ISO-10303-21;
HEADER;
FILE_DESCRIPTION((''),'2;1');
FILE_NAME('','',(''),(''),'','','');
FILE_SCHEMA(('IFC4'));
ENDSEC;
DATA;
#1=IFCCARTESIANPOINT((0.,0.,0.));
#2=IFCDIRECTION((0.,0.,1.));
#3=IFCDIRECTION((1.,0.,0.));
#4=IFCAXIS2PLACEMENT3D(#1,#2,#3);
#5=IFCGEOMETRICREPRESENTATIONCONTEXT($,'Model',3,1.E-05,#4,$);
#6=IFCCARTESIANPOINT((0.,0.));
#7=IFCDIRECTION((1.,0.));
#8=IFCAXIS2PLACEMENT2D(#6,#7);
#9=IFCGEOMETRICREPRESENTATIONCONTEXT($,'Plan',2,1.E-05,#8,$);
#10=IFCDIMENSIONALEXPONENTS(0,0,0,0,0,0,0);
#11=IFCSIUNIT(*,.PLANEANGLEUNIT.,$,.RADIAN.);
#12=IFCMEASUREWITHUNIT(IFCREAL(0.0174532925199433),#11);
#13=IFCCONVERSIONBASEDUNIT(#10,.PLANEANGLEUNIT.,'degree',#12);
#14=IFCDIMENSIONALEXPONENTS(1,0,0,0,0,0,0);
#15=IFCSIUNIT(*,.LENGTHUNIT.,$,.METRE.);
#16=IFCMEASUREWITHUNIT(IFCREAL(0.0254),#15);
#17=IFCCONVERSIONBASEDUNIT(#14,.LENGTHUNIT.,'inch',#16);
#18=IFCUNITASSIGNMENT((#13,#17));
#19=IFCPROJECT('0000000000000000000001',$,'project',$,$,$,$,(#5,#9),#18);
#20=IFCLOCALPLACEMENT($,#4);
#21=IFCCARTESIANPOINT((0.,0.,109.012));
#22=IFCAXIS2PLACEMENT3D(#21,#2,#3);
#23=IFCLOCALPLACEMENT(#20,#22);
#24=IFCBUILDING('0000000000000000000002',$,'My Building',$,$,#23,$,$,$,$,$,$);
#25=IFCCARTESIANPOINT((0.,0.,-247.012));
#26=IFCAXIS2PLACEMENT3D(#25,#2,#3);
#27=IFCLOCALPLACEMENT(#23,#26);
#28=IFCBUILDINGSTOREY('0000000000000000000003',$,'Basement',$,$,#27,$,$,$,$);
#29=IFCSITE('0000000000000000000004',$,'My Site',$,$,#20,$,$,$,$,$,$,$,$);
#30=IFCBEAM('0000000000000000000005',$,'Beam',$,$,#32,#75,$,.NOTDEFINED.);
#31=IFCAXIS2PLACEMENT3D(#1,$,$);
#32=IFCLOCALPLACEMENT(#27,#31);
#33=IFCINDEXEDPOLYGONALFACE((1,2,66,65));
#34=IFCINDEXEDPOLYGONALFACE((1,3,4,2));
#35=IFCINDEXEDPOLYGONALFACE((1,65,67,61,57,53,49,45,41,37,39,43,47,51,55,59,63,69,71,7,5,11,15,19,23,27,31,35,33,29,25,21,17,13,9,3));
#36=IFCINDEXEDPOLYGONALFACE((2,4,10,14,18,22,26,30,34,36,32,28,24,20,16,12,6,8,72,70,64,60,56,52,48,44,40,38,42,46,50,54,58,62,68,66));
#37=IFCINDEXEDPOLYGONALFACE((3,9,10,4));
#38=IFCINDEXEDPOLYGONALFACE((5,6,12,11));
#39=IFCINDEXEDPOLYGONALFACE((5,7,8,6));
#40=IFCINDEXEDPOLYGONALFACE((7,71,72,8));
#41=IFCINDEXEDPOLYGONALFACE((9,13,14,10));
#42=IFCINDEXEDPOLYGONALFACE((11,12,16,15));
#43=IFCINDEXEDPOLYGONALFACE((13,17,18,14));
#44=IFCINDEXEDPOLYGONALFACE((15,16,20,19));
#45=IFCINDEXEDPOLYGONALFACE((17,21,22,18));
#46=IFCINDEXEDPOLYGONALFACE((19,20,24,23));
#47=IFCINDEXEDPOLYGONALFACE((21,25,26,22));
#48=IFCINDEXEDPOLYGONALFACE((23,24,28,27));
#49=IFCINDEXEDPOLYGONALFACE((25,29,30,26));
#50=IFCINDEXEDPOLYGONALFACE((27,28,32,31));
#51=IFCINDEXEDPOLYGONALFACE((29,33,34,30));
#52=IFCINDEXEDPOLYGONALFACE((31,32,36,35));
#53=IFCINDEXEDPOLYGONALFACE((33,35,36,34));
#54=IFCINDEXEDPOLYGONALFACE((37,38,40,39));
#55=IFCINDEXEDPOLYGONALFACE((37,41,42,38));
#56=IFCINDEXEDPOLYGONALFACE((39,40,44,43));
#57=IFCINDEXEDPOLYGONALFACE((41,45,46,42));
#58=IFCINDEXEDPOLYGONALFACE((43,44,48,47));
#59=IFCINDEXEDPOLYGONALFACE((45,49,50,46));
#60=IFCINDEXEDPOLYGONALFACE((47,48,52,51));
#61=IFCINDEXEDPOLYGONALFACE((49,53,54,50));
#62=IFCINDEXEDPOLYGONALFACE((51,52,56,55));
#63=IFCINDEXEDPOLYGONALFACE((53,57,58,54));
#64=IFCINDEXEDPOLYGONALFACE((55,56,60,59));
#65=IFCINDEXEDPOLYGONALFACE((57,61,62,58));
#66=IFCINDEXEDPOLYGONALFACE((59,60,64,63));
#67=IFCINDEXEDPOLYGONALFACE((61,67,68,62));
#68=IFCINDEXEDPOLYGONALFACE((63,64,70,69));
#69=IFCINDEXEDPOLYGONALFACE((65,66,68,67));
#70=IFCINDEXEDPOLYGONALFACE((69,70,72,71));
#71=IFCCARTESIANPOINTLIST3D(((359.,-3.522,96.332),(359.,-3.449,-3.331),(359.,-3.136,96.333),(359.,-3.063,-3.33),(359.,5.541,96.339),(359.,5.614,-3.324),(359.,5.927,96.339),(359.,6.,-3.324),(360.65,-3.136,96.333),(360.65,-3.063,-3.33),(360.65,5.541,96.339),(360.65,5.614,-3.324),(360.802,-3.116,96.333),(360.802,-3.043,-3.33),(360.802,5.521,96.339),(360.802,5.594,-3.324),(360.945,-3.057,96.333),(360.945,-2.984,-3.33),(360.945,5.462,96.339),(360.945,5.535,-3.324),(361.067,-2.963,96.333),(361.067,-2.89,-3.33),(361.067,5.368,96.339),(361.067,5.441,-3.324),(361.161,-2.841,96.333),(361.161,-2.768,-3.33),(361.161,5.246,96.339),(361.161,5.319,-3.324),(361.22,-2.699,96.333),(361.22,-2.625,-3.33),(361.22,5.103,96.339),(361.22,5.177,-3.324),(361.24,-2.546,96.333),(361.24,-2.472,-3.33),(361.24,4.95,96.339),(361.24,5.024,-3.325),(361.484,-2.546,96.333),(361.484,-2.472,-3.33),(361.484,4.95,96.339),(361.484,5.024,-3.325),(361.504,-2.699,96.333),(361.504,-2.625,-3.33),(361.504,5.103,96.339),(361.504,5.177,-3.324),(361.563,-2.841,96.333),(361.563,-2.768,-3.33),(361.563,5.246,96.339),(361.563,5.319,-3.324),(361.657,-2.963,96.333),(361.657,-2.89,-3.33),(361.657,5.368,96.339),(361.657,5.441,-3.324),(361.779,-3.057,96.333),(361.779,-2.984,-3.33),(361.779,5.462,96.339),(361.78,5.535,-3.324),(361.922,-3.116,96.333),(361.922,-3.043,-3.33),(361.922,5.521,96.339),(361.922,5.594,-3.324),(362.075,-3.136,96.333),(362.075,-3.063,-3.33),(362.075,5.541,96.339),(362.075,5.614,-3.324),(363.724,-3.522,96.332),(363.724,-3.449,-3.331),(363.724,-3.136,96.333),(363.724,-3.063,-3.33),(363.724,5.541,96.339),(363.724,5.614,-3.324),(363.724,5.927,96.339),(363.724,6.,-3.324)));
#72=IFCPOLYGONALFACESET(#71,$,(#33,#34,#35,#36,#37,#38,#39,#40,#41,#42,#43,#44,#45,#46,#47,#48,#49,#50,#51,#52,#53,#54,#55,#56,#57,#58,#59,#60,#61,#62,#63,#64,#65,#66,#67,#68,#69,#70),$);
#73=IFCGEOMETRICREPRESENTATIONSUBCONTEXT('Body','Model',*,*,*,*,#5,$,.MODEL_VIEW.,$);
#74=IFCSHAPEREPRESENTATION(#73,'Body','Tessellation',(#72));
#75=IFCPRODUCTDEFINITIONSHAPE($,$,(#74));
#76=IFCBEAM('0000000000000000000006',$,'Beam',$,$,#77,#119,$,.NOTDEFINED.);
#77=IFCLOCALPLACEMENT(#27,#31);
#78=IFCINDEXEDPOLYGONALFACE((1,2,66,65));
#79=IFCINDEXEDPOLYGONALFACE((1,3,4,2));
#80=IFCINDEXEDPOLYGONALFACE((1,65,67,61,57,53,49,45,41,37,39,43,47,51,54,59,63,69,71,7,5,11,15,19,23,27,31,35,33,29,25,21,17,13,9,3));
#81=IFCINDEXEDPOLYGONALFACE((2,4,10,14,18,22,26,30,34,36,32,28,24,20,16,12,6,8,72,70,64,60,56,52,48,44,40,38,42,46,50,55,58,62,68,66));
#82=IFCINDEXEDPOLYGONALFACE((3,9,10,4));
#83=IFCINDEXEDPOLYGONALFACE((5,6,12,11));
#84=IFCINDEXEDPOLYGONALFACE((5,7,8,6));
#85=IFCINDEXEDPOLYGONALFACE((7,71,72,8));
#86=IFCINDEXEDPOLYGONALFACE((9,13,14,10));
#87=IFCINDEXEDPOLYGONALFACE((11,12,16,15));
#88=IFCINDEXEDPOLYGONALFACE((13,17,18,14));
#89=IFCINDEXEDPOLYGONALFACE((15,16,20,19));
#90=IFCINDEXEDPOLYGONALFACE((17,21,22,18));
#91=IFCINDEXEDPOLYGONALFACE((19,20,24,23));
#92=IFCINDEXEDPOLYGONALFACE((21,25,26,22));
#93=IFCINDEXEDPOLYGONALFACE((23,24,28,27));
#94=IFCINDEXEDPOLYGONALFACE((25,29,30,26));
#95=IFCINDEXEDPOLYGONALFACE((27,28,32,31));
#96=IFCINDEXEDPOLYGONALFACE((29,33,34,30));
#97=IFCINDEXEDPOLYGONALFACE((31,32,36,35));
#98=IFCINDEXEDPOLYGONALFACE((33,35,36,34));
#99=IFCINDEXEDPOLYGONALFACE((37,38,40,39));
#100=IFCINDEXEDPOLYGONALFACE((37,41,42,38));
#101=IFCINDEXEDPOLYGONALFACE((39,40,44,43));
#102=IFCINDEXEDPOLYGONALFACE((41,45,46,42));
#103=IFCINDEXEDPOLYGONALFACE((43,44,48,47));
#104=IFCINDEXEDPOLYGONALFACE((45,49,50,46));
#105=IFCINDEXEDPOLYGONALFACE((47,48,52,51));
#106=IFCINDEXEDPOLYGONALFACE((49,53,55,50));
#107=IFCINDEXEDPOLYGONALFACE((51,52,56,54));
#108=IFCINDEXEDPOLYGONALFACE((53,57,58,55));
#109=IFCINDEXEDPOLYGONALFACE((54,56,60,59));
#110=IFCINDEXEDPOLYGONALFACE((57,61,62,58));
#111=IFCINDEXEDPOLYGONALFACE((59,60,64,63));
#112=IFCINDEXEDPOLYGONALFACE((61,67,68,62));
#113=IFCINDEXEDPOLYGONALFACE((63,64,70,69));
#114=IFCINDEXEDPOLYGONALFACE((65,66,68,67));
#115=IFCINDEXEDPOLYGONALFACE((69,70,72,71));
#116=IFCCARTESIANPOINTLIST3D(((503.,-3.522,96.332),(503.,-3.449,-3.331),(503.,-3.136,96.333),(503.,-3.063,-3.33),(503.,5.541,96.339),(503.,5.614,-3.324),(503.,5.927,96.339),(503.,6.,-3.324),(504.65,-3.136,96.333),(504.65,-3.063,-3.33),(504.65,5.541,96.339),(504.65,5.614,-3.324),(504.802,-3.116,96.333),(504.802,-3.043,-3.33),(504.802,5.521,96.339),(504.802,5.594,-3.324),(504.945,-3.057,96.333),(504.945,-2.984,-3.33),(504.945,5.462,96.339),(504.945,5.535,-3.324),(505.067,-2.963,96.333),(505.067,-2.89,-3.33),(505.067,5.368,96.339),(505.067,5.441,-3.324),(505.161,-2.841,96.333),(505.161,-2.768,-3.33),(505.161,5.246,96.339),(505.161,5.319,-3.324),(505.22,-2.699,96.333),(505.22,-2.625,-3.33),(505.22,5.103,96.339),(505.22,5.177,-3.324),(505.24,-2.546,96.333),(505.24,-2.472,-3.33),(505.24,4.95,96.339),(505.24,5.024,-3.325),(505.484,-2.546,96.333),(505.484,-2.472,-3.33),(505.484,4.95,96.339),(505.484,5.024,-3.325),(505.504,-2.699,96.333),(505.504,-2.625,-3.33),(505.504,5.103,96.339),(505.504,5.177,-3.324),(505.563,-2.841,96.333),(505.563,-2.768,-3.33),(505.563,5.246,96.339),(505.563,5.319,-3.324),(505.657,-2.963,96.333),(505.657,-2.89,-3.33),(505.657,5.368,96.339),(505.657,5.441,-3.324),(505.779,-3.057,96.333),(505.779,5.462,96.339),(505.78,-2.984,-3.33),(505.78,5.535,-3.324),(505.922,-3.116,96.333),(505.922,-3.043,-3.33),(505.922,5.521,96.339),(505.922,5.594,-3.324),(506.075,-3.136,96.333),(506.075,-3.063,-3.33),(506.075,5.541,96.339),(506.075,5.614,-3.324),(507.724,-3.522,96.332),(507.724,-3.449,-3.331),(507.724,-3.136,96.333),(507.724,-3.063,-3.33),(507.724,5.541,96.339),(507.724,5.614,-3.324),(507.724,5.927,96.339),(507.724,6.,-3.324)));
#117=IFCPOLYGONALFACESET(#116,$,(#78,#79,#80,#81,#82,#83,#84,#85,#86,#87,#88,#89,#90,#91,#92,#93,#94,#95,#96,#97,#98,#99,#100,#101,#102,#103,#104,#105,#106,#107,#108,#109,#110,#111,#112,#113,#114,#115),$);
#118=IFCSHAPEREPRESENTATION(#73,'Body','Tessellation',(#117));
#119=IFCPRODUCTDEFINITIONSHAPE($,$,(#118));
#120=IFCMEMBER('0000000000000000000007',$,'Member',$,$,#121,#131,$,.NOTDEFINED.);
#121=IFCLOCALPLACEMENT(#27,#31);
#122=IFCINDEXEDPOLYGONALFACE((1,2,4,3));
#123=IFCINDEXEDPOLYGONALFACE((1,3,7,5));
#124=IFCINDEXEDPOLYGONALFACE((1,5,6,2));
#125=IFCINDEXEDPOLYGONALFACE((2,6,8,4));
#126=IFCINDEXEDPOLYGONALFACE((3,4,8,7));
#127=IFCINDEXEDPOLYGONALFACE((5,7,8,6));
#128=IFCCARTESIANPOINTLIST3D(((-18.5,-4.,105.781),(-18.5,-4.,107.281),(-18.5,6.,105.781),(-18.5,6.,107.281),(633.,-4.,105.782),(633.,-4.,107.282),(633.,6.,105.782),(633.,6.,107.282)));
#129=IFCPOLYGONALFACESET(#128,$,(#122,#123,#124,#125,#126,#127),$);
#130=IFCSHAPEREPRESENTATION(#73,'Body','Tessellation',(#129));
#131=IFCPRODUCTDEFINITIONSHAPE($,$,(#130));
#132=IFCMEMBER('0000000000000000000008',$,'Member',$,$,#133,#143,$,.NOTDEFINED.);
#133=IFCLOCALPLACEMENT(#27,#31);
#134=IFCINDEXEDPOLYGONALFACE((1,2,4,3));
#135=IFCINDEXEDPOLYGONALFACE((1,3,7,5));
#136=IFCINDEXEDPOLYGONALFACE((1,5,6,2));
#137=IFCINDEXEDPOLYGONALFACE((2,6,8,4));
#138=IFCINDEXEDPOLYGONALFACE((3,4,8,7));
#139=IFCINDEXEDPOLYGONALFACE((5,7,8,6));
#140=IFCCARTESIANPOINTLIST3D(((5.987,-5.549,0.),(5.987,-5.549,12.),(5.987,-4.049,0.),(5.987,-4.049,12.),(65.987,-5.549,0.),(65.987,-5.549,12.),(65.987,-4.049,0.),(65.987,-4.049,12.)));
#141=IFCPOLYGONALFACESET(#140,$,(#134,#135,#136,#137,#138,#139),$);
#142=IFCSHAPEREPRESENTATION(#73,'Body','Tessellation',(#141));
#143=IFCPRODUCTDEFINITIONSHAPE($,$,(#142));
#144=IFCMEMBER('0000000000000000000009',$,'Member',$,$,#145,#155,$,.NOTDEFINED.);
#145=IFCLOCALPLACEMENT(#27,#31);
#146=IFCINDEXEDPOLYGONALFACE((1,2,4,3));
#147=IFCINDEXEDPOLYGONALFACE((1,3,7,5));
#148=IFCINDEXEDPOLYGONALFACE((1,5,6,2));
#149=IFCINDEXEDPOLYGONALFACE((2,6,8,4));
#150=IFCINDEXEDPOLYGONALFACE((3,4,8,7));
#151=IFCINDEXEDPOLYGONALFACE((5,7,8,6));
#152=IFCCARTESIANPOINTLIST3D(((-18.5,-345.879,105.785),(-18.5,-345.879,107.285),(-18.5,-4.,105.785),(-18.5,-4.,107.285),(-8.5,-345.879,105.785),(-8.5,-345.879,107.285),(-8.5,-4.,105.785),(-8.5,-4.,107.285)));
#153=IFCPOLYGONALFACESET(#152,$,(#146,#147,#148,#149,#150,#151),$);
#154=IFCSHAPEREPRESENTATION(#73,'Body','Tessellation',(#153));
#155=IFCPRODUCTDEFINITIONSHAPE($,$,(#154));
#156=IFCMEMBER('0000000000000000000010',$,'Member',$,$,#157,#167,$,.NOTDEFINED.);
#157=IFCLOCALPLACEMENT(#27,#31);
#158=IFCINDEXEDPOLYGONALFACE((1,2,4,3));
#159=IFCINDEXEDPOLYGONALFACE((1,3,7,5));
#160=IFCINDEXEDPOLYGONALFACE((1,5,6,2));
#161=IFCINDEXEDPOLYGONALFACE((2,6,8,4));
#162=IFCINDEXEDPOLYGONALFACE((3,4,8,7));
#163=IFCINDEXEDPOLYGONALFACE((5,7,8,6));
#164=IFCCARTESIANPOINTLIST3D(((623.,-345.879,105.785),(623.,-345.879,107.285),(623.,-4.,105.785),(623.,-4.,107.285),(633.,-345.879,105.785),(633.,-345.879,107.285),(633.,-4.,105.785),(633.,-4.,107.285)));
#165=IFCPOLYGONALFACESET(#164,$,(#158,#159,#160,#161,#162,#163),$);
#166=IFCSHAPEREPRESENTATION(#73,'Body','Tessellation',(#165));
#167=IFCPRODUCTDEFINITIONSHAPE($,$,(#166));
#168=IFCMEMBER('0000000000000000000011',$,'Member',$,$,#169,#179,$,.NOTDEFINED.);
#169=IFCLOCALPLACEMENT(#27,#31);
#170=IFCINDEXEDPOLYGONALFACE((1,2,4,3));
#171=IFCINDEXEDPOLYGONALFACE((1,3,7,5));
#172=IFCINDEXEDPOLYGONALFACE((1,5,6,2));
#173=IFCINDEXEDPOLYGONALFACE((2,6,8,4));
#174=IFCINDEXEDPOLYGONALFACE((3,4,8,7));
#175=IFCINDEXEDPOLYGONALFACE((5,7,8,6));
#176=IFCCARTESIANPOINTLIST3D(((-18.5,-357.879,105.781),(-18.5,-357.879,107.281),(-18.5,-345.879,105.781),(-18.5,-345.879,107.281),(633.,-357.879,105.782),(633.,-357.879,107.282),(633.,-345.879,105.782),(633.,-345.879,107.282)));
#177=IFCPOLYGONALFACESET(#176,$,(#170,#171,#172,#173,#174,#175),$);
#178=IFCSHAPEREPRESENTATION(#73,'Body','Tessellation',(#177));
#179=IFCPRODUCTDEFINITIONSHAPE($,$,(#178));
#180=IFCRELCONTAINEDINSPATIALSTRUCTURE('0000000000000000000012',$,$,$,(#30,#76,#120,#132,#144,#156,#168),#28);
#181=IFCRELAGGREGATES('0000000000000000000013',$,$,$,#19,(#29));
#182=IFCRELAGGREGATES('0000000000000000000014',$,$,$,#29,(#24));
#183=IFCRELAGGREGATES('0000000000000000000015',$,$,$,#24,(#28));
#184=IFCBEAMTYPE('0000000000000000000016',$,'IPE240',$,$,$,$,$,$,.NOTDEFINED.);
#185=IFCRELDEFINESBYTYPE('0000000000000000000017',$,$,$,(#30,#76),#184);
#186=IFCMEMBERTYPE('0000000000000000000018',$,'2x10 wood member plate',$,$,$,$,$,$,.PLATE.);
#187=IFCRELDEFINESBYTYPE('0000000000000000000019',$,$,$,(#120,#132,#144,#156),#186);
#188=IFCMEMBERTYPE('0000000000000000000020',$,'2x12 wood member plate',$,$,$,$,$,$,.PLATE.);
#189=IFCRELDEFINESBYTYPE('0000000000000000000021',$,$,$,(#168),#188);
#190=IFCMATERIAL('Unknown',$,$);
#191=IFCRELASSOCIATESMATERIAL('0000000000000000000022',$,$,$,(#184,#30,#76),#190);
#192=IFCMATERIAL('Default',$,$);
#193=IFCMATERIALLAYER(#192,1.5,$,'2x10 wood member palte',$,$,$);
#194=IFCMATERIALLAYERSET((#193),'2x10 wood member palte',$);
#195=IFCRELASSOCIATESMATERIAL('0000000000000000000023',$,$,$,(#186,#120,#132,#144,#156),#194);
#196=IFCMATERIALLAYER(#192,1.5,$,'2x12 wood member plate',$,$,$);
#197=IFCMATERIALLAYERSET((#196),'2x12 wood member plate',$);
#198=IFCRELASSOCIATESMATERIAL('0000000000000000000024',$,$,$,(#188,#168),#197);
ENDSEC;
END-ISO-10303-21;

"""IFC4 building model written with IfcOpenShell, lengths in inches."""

from ifc_helpers import new_model, entity, si_unit, converted_unit, frame, origin_with_axes, origin_2d_with_axis, place, context, subcontext, project, spatial, indexed_curve, i_section, outline, extrude, material, layer, layer_set, layer_usage, material_profile, profile_set, profile_usage, type_object, element, save


model = new_model("IFC4")

# Units and contexts
model_context = context("Model", 3, precision=1e-05, world=origin_with_axes())
plan_context = context("Plan", 2, precision=1e-05, world=origin_2d_with_axis())
body_context = subcontext(model_context, "Body", "Model", "MODEL_VIEW")
ifc_project = project(units=[converted_unit("PLANEANGLEUNIT", "degree", entity("IfcReal", 0.0174532925199433), si_unit("PLANEANGLEUNIT", "RADIAN"), dimensions=[0, 0, 0, 0, 0, 0, 0]), converted_unit("LENGTHUNIT", "inch", entity("IfcReal", 0.0254), si_unit("LENGTHUNIT", "METRE"), dimensions=[1, 0, 0, 0, 0, 0, 0])], contexts=[model_context, plan_context])

# Site, building, storey
site_placement = place(None, origin_with_axes())
site = spatial("IfcSite", under=ifc_project, at=site_placement, Name="My Site")
building_placement = place(site_placement, frame((0.0, 0.0, 109.012), z_axis=(0.0, 0.0, 1.0), x_axis=(1.0, 0.0, 0.0)))
building = spatial("IfcBuilding", under=site, at=building_placement, Name="My Building")
storey_placement = place(building_placement, frame((0.0, 0.0, -247.012), z_axis=(0.0, 0.0, 1.0), x_axis=(1.0, 0.0, 0.0)))
storey = spatial("IfcBuildingStorey", under=building, at=storey_placement, Name="Basement")

# Shared definitions
ifc_material_1 = material(Name="Default")

# Beams
ifc_material_2 = material(Name="Unknown")
ifc_material_profile = material_profile(ifc_material_2, i_section(OverallWidth=4.724, OverallDepth=9.449, WebThickness=0.244, FlangeThickness=0.386, FilletRadius=0.591))
ifc_profile_set = profile_set([ifc_material_profile])
beam_type_1 = type_object("IfcBeamType", Name="IPE240", PredefinedType="NOTDEFINED", material=ifc_profile_set)
ifc_profile_usage_1 = profile_usage(ifc_profile_set, cardinal=11)
beam_1_placement = place(storey_placement, frame((361.362, 1.276, -3.327), z_axis=(0.0, -0.000737, 1.0), x_axis=(1.0, -0.000003, 0.0)))
element("IfcBeam", 1, at=beam_1_placement, inside=storey, type_object=beam_type_1, material=ifc_profile_usage_1, Name="Beam", PredefinedType="NOTDEFINED", context=body_context, shape_type="SweptSolid", body=[
    extrude(i_section(OverallWidth=4.724, OverallDepth=9.449, WebThickness=0.244, FlangeThickness=0.386, FilletRadius=0.591), origin_with_axes(), (0.0, 0.0, 1.0), 99.663),
])
ifc_profile_usage_2 = profile_usage(ifc_profile_set, cardinal=11)
beam_2_placement = place(storey_placement, frame((505.362, 1.276, -3.327), z_axis=(0.0, -0.000737, 1.0), x_axis=(1.0, -0.000003, 0.0)))
element("IfcBeam", 2, at=beam_2_placement, inside=storey, type_object=beam_type_1, material=ifc_profile_usage_2, Name="Beam", PredefinedType="NOTDEFINED", context=body_context, shape_type="SweptSolid", body=[
    extrude(i_section(OverallWidth=4.724, OverallDepth=9.449, WebThickness=0.244, FlangeThickness=0.386, FilletRadius=0.591), origin_with_axes(), (0.0, 0.0, 1.0), 99.663),
])

# Members
ifc_layer_1 = layer(ifc_material_1, 1.5, Name="2x10 wood member palte")
ifc_layer_set_1 = layer_set([ifc_layer_1], Name="2x10 wood member palte")
ifc_layer_usage_1 = layer_usage(ifc_layer_set_1, "AXIS2", "POSITIVE", 0.0)
member_type_1 = type_object("IfcMemberType", Name="2x10 wood member plate", PredefinedType="PLATE", material=ifc_layer_set_1)
member_1_placement = place(storey_placement, frame((-18.5, -4.0, 107.281), z_axis=(0.0, 1.0, -0.000007), x_axis=(1.0, 0.0, 0.000001)))
element("IfcMember", 3, at=member_1_placement, inside=storey, type_object=member_type_1, material=ifc_layer_usage_1, Name="Member", PredefinedType="NOTDEFINED", context=body_context, shape_type="SweptSolid", body=[
    extrude(outline(indexed_curve([(0.0, 0.0), (0.0, 1.5), (651.5, 1.5), (651.5, 0.0), (0.0, 0.0)], self_intersect=False)), origin_with_axes(), (0.0, 0.0, 1.0), 10.0),
])
ifc_layer_usage_2 = layer_usage(ifc_layer_set_1, "AXIS2", "POSITIVE", 0.0)
member_2_placement = place(storey_placement, frame((5.987, -5.549, 0.0), z_axis=(0.0, 0.0, 1.0), x_axis=(1.0, 0.0, 0.0)))
element("IfcMember", 4, at=member_2_placement, inside=storey, type_object=member_type_1, material=ifc_layer_usage_2, Name="Member", PredefinedType="NOTDEFINED", context=body_context, shape_type="SweptSolid", body=[
    extrude(outline(indexed_curve([(0.0, 0.0), (0.0, 1.5), (60.0, 1.5), (60.0, 0.0), (0.0, 0.0)], self_intersect=False)), origin_with_axes(), (0.0, 0.0, 1.0), 12.0),
])
ifc_layer_usage_3 = layer_usage(ifc_layer_set_1, "AXIS2", "POSITIVE", 0.0)
member_3_placement = place(storey_placement, frame((-18.5, -4.0, 107.285), z_axis=(1.0, 0.0, 0.0), x_axis=(0.0, -1.0, 0.000001)))
element("IfcMember", 5, at=member_3_placement, inside=storey, type_object=member_type_1, material=ifc_layer_usage_3, Name="Member", PredefinedType="NOTDEFINED", context=body_context, shape_type="SweptSolid", body=[
    extrude(outline(indexed_curve([(0.0, 0.0), (0.0, 1.5), (341.879, 1.5), (341.879, 0.0), (0.0, 0.0)], self_intersect=False)), origin_with_axes(), (0.0, 0.0, 1.0), 10.0),
])
ifc_layer_usage_4 = layer_usage(ifc_layer_set_1, "AXIS2", "POSITIVE", 0.0)
member_4_placement = place(storey_placement, frame((623.0, -4.0, 107.285), z_axis=(1.0, 0.0, 0.0), x_axis=(0.0, -1.0, 0.000001)))
element("IfcMember", 6, at=member_4_placement, inside=storey, type_object=member_type_1, material=ifc_layer_usage_4, Name="Member", PredefinedType="NOTDEFINED", context=body_context, shape_type="SweptSolid", body=[
    extrude(outline(indexed_curve([(0.0, 0.0), (0.0, 1.5), (341.879, 1.5), (341.879, 0.0), (0.0, 0.0)], self_intersect=False)), origin_with_axes(), (0.0, 0.0, 1.0), 10.0),
])
ifc_layer_2 = layer(ifc_material_1, 1.5, Name="2x12 wood member plate")
ifc_layer_set_2 = layer_set([ifc_layer_2], Name="2x12 wood member plate")
ifc_layer_usage_5 = layer_usage(ifc_layer_set_2, "AXIS2", "POSITIVE", 0.0)
member_type_2 = type_object("IfcMemberType", Name="2x12 wood member plate", PredefinedType="PLATE", material=ifc_layer_set_2)
member_5_placement = place(storey_placement, frame((-18.5, -357.879, 107.281), z_axis=(0.0, 1.0, -0.000007), x_axis=(1.0, 0.0, 0.000001)))
element("IfcMember", 7, at=member_5_placement, inside=storey, type_object=member_type_2, material=ifc_layer_usage_5, Name="Member", PredefinedType="NOTDEFINED", context=body_context, shape_type="SweptSolid", body=[
    extrude(outline(indexed_curve([(0.0, 0.0), (0.0, 1.5), (651.5, 1.5), (651.5, 0.0), (0.0, 0.0)], self_intersect=False)), origin_with_axes(), (0.0, 0.0, 1.0), 12.0),
])

save(model, "model.ifc")
